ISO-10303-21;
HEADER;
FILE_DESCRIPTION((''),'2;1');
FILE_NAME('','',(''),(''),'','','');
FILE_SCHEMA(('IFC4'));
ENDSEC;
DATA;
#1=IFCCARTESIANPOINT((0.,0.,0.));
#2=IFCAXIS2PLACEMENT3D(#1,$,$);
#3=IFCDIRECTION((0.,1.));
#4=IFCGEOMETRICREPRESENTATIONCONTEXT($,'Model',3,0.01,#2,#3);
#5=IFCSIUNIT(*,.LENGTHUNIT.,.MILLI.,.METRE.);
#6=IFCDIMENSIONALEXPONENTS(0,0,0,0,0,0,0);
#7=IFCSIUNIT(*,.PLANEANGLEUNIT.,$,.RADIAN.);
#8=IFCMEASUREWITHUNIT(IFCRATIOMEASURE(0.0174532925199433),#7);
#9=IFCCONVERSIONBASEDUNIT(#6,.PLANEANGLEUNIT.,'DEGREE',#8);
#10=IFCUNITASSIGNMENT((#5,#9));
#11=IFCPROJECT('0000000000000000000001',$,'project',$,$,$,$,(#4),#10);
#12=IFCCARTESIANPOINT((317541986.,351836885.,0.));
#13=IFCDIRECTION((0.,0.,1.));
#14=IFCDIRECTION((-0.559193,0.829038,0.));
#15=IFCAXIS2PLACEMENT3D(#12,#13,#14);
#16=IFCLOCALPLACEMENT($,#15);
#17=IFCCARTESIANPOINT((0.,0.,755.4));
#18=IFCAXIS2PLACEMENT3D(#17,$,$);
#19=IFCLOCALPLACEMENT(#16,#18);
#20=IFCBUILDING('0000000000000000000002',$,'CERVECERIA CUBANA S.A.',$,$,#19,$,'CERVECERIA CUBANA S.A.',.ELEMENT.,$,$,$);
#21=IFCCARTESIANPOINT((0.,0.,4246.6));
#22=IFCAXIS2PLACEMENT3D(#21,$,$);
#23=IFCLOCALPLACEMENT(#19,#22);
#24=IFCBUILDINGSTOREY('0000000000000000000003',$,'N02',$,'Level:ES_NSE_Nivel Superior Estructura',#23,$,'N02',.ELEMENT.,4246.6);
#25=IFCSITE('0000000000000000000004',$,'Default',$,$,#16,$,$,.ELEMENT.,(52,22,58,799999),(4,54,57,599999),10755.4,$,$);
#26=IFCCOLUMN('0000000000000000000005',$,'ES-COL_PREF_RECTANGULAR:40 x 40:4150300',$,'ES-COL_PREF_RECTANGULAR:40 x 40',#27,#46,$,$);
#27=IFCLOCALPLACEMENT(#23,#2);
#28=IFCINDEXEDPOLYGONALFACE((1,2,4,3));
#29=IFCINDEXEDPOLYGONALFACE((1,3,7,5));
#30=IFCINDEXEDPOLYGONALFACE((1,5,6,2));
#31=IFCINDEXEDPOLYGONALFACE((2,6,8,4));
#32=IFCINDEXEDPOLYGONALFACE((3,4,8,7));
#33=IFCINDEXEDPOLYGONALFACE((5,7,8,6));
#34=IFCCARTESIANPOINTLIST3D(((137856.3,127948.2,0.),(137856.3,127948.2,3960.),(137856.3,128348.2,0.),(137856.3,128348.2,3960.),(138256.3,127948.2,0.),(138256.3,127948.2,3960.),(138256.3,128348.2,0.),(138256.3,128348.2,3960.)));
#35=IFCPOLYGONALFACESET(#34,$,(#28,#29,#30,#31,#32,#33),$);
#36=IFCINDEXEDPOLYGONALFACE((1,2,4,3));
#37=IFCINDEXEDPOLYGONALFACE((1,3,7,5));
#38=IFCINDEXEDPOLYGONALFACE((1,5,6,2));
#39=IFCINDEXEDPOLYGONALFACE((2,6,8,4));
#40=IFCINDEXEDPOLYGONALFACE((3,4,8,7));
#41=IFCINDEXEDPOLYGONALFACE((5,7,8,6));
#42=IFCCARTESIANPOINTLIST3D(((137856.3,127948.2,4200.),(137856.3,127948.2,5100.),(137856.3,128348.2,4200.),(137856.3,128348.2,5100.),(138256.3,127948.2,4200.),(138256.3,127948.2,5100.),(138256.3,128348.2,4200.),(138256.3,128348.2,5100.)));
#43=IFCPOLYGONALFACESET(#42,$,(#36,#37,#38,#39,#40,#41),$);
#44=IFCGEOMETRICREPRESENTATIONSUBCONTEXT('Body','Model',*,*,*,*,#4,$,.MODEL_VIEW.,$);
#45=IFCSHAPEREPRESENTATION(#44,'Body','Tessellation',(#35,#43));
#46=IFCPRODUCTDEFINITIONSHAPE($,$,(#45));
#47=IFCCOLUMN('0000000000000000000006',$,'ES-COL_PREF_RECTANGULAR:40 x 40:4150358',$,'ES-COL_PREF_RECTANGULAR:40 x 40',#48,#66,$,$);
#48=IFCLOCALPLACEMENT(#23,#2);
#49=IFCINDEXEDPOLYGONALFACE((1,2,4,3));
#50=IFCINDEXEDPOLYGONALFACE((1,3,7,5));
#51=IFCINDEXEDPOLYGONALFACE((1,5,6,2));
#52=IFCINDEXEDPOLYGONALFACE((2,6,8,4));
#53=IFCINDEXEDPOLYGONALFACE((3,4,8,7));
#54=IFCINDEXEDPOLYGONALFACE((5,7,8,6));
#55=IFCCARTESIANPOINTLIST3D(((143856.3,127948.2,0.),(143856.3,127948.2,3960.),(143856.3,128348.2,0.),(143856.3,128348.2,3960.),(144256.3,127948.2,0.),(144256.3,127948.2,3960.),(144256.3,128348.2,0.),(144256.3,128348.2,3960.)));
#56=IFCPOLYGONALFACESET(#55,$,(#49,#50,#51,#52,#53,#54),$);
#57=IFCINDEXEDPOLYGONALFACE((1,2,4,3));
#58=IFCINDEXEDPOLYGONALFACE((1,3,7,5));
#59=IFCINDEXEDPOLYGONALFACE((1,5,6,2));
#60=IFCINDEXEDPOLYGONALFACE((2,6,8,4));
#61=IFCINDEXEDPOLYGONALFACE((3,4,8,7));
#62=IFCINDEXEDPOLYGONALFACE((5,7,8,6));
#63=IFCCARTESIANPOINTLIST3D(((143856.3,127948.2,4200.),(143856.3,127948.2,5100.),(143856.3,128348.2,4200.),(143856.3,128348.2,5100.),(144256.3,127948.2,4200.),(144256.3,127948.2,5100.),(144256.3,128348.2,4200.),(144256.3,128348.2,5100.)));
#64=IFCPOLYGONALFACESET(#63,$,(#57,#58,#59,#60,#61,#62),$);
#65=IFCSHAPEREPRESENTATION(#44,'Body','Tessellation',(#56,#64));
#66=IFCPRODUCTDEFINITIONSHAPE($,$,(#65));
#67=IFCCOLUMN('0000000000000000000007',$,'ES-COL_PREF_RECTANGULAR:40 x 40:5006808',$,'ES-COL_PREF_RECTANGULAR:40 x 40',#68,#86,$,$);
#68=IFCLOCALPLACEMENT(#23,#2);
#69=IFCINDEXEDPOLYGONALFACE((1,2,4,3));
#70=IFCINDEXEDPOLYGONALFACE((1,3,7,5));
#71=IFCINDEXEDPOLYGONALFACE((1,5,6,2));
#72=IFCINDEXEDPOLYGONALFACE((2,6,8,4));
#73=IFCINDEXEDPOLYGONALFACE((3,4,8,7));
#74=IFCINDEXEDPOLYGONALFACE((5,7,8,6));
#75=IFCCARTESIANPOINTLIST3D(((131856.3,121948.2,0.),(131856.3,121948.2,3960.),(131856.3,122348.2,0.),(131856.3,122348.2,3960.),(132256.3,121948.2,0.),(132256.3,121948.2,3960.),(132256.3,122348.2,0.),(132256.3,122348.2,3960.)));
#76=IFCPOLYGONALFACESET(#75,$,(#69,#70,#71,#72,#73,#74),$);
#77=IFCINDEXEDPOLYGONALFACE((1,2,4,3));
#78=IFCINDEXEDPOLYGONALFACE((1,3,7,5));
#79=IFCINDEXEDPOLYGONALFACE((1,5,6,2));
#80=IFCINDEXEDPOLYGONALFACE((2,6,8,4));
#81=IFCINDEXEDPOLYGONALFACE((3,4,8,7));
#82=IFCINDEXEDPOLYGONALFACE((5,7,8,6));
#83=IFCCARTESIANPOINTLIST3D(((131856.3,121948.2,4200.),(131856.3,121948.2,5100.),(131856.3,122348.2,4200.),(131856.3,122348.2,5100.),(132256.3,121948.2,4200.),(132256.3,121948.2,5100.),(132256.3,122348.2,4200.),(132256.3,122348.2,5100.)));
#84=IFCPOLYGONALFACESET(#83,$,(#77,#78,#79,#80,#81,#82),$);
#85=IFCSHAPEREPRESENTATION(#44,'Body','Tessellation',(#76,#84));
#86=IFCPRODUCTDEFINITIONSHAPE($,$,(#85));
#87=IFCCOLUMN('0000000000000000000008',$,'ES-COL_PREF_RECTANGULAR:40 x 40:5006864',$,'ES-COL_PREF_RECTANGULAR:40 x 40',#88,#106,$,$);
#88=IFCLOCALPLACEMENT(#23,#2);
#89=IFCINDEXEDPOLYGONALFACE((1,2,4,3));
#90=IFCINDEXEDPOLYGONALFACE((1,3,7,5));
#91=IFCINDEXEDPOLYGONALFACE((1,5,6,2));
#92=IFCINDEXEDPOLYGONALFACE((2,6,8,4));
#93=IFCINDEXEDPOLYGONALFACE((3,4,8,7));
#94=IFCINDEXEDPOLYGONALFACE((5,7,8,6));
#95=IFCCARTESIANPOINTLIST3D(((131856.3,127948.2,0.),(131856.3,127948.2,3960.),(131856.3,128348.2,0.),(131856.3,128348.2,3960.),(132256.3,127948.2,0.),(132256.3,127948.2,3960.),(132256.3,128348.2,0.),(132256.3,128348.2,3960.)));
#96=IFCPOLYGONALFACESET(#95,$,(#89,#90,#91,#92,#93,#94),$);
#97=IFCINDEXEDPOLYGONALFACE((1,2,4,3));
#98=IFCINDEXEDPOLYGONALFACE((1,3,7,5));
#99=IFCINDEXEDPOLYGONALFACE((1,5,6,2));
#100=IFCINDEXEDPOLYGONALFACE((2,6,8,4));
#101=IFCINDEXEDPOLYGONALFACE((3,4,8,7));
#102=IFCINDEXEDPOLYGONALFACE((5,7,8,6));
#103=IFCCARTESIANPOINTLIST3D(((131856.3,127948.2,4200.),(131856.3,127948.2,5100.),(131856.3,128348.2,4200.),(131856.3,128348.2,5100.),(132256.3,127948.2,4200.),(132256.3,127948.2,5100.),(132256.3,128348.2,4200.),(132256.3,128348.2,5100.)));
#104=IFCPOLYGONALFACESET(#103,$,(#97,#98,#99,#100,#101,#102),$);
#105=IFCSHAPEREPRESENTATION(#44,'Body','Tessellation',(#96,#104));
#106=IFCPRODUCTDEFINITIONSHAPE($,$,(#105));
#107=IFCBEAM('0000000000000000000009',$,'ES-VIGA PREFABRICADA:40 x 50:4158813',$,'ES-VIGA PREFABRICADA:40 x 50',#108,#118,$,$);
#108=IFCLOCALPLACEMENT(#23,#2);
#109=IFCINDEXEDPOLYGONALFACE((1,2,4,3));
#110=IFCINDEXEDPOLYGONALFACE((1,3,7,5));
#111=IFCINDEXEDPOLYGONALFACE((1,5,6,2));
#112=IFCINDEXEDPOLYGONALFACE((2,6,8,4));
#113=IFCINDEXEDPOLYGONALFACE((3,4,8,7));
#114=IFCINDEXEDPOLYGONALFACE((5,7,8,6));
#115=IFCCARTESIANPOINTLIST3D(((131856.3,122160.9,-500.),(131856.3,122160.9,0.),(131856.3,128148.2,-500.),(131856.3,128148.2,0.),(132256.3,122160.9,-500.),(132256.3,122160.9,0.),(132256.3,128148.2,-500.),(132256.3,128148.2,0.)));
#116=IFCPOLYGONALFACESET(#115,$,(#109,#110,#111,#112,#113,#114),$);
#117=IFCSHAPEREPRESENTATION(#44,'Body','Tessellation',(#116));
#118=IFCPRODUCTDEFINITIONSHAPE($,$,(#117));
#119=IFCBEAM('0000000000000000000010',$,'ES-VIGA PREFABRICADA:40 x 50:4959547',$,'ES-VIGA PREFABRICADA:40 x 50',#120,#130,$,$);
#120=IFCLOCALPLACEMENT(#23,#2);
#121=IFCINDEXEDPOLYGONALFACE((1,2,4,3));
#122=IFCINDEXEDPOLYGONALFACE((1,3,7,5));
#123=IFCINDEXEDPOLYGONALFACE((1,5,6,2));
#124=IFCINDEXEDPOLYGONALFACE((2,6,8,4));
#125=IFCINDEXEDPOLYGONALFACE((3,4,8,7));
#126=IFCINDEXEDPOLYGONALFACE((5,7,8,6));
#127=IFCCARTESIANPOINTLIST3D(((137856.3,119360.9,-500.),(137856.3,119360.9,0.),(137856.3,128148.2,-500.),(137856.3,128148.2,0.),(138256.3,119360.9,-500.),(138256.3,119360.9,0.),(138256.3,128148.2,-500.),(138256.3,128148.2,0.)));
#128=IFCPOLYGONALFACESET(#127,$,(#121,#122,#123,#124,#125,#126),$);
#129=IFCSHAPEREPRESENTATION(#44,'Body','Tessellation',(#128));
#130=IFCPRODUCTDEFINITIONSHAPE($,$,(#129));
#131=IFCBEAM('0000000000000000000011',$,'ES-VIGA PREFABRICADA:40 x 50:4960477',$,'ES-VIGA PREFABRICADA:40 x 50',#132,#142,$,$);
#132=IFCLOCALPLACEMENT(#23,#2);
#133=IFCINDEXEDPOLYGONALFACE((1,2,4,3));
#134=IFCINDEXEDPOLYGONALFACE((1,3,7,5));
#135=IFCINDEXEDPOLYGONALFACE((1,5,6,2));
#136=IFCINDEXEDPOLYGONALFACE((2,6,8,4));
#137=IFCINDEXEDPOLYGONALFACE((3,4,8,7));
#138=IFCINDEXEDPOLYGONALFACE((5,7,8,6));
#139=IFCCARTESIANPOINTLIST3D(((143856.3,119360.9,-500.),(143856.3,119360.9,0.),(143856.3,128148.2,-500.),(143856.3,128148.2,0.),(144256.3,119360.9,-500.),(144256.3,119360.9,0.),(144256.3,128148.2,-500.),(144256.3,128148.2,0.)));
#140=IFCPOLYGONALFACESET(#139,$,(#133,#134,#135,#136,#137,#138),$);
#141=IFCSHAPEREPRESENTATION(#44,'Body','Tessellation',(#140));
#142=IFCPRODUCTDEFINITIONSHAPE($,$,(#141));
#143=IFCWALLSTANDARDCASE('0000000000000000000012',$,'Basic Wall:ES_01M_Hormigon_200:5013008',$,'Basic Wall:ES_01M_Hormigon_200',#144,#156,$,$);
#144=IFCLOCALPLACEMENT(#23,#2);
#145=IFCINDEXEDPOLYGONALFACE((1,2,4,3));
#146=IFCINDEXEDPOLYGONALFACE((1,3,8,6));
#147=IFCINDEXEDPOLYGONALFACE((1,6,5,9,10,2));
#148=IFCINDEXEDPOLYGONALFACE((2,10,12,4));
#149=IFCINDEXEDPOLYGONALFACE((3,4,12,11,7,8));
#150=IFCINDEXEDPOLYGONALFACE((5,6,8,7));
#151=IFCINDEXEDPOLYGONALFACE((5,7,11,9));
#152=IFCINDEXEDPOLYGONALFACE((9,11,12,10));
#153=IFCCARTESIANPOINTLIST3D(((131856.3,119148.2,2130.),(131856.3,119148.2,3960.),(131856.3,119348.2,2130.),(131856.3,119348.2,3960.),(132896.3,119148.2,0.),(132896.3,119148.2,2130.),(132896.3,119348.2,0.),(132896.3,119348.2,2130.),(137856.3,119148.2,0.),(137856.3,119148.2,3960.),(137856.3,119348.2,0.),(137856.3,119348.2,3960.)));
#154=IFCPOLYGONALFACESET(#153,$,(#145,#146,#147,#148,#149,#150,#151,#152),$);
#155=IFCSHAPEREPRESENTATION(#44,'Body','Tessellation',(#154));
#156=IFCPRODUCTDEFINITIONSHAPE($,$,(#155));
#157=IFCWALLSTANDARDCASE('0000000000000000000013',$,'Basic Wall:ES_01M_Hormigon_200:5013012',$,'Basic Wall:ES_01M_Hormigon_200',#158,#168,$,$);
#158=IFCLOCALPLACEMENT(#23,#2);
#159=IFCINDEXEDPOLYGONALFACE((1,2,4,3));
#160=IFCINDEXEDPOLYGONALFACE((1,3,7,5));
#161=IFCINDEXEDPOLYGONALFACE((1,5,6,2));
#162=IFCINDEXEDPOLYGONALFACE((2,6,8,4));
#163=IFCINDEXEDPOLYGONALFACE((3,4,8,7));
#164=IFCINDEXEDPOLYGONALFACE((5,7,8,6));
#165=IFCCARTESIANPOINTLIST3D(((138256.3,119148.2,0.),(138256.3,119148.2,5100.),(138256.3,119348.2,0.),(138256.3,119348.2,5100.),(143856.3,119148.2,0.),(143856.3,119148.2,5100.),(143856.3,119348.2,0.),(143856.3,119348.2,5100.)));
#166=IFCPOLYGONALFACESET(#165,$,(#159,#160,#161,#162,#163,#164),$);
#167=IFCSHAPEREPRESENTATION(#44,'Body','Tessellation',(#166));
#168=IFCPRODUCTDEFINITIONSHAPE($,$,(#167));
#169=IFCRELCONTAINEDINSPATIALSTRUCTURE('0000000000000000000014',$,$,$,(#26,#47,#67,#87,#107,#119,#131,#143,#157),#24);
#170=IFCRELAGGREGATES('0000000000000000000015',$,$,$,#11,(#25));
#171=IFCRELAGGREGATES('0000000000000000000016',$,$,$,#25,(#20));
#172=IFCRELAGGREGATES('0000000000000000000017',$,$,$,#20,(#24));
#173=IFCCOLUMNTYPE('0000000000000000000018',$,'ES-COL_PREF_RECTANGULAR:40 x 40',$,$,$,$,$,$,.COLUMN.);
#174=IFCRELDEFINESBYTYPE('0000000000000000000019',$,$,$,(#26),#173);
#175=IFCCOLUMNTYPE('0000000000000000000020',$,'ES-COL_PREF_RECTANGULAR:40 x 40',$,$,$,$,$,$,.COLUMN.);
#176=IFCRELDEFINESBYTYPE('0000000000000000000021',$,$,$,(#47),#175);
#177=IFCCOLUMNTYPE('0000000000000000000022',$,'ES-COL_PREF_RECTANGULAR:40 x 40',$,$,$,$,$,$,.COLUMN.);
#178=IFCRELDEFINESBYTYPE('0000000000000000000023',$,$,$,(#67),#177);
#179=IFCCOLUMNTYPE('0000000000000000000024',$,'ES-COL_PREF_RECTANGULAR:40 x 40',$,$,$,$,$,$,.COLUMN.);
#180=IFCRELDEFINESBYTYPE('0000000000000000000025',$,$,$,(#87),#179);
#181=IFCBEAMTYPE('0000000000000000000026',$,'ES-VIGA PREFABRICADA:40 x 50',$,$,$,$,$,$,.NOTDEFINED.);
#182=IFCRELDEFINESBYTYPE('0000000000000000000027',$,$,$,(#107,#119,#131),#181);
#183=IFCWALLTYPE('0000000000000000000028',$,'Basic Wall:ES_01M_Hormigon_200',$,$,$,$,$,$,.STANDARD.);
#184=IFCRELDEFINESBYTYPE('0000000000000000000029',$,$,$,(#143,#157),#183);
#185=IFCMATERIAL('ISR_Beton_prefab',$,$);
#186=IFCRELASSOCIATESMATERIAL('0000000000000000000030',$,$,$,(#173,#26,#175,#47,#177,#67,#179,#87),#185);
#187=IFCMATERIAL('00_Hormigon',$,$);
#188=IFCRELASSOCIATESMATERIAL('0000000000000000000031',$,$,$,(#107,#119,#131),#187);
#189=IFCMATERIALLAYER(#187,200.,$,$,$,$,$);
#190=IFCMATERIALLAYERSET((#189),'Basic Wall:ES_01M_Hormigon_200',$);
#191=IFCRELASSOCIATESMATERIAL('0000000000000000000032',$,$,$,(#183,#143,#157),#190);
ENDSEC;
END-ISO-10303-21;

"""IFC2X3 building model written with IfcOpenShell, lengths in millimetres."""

from ifc_helpers import new_model, entity, si_unit, converted_unit, direction, frame, frame_2d, origin, origin_2d_with_axis, place, context, subcontext, project, spatial, rectangle, extrude, source, transform, mapped, material, layer, layer_set, layer_usage, type_object, type_shapes, element, save


model = new_model("IFC2X3")

# Units and contexts
model_context = context("Model", 3, precision=0.01, world=origin(), true_north=direction((0.0, 1.0)))
body_context = subcontext(model_context, "Body", "Model", "MODEL_VIEW")
ifc_project = project(units=[si_unit("LENGTHUNIT", "METRE", prefix="MILLI"), converted_unit("PLANEANGLEUNIT", "DEGREE", entity("IfcRatioMeasure", 0.0174532925199433), si_unit("PLANEANGLEUNIT", "RADIAN"), dimensions=[0, 0, 0, 0, 0, 0, 0])], contexts=[model_context])

# Site, building, storey
site_placement = place(None, frame((317541986.0, 351836885.0, 0.0), z_axis=(0.0, 0.0, 1.0), x_axis=(-0.559193, 0.829038, 0.0)))
site = spatial("IfcSite", under=ifc_project, at=site_placement, Name="Default", CompositionType="ELEMENT", RefLatitude=(52, 22, 58, 799999), RefLongitude=(4, 54, 57, 599999), RefElevation=10755.4)
building_placement = place(site_placement, frame((0.0, 0.0, 755.4)))
building = spatial("IfcBuilding", under=site, at=building_placement, Name="CERVECERIA CUBANA S.A.", LongName="CERVECERIA CUBANA S.A.", CompositionType="ELEMENT")
storey_placement = place(building_placement, frame((0.0, 0.0, 4246.6)))
storey = spatial("IfcBuildingStorey", under=building, at=storey_placement, Name="N02", ObjectType="Level:ES_NSE_Nivel Superior Estructura", LongName="N02", CompositionType="ELEMENT", Elevation=4246.6)

# Columns
ifc_material_1 = material(Name="ISR_Beton_prefab")
column_type_1 = type_object("IfcColumnType", Name="ES-COL_PREF_RECTANGULAR:40 x 40", PredefinedType="COLUMN", material=ifc_material_1)
shared_shape_1 = source(origin(), body_context, "Body", "SweptSolid", [
    extrude(rectangle(XDim=400.0, YDim=400.0, at=origin_2d_with_axis()), frame((138056.3, 128148.2, 4246.6), z_axis=(0.0, 0.0, 1.0), x_axis=(0.0, -1.0, 0.0)), (0.0, 0.0, 1.0), 3960.0),
    extrude(rectangle(XDim=400.0, YDim=400.0, at=origin_2d_with_axis()), frame((138056.3, 128148.2, 8446.6), z_axis=(0.0, 0.0, 1.0), x_axis=(0.0, -1.0, 0.0)), (0.0, 0.0, 1.0), 900.0),
])
type_shapes(column_type_1, [shared_shape_1])
column_1_placement = place(storey_placement, frame((0.0, 0.0, -4246.6)))
element("IfcColumn", 1, at=column_1_placement, inside=storey, type_object=column_type_1, material=ifc_material_1, Name="ES-COL_PREF_RECTANGULAR:40 x 40:4150300", ObjectType="ES-COL_PREF_RECTANGULAR:40 x 40", context=body_context, shape_type="MappedRepresentation", body=[
    mapped(shared_shape_1, transform((0.0, 0.0, 0.0), scale=1.0)),
])
column_type_2 = type_object("IfcColumnType", Name="ES-COL_PREF_RECTANGULAR:40 x 40", PredefinedType="COLUMN", material=ifc_material_1)
shared_shape_2 = source(origin(), body_context, "Body", "SweptSolid", [
    extrude(rectangle(XDim=400.0, YDim=400.0, at=origin_2d_with_axis()), frame((144056.3, 128148.2, 4246.6), z_axis=(0.0, 0.0, 1.0), x_axis=(0.0, -1.0, 0.0)), (0.0, 0.0, 1.0), 3960.0),
    extrude(rectangle(XDim=400.0, YDim=400.0, at=origin_2d_with_axis()), frame((144056.3, 128148.2, 8446.6), z_axis=(0.0, 0.0, 1.0), x_axis=(0.0, -1.0, 0.0)), (0.0, 0.0, 1.0), 900.0),
])
type_shapes(column_type_2, [shared_shape_2])
column_2_placement = place(storey_placement, frame((0.0, 0.0, -4246.6)))
element("IfcColumn", 2, at=column_2_placement, inside=storey, type_object=column_type_2, material=ifc_material_1, Name="ES-COL_PREF_RECTANGULAR:40 x 40:4150358", ObjectType="ES-COL_PREF_RECTANGULAR:40 x 40", context=body_context, shape_type="MappedRepresentation", body=[
    mapped(shared_shape_2, transform((0.0, 0.0, 0.0), scale=1.0)),
])
column_type_3 = type_object("IfcColumnType", Name="ES-COL_PREF_RECTANGULAR:40 x 40", PredefinedType="COLUMN", material=ifc_material_1)
shared_shape_3 = source(origin(), body_context, "Body", "SweptSolid", [
    extrude(rectangle(XDim=400.0, YDim=400.0, at=origin_2d_with_axis()), frame((132056.3, 122148.2, 4246.6), z_axis=(0.0, 0.0, 1.0), x_axis=(0.0, -1.0, 0.0)), (0.0, 0.0, 1.0), 3960.0),
    extrude(rectangle(XDim=400.0, YDim=400.0, at=origin_2d_with_axis()), frame((132056.3, 122148.2, 8446.6), z_axis=(0.0, 0.0, 1.0), x_axis=(0.0, -1.0, 0.0)), (0.0, 0.0, 1.0), 900.0),
])
type_shapes(column_type_3, [shared_shape_3])
column_3_placement = place(storey_placement, frame((0.0, 0.0, -4246.6)))
element("IfcColumn", 3, at=column_3_placement, inside=storey, type_object=column_type_3, material=ifc_material_1, Name="ES-COL_PREF_RECTANGULAR:40 x 40:5006808", ObjectType="ES-COL_PREF_RECTANGULAR:40 x 40", context=body_context, shape_type="MappedRepresentation", body=[
    mapped(shared_shape_3, transform((0.0, 0.0, 0.0), scale=1.0)),
])
column_type_4 = type_object("IfcColumnType", Name="ES-COL_PREF_RECTANGULAR:40 x 40", PredefinedType="COLUMN", material=ifc_material_1)
shared_shape_4 = source(origin(), body_context, "Body", "SweptSolid", [
    extrude(rectangle(XDim=400.0, YDim=400.0, at=origin_2d_with_axis()), frame((132056.3, 128148.2, 4246.6), z_axis=(0.0, 0.0, 1.0), x_axis=(0.0, -1.0, 0.0)), (0.0, 0.0, 1.0), 3960.0),
    extrude(rectangle(XDim=400.0, YDim=400.0, at=origin_2d_with_axis()), frame((132056.3, 128148.2, 8446.6), z_axis=(0.0, 0.0, 1.0), x_axis=(0.0, -1.0, 0.0)), (0.0, 0.0, 1.0), 900.0),
])
type_shapes(column_type_4, [shared_shape_4])
column_4_placement = place(storey_placement, frame((0.0, 0.0, -4246.6)))
element("IfcColumn", 4, at=column_4_placement, inside=storey, type_object=column_type_4, material=ifc_material_1, Name="ES-COL_PREF_RECTANGULAR:40 x 40:5006864", ObjectType="ES-COL_PREF_RECTANGULAR:40 x 40", context=body_context, shape_type="MappedRepresentation", body=[
    mapped(shared_shape_4, transform((0.0, 0.0, 0.0), scale=1.0)),
])

# Beams
ifc_material_2 = material(Name="00_Hormigon")
beam_type = type_object("IfcBeamType", Name="ES-VIGA PREFABRICADA:40 x 50", PredefinedType="NOTDEFINED")
beam_1_placement = place(storey_placement, frame((132056.3, 128148.2, 0.0), z_axis=(0.0, 0.0, 1.0), x_axis=(0.0, -1.0, 0.0)))
element("IfcBeam", 5, at=beam_1_placement, inside=storey, type_object=beam_type, material=ifc_material_2, Name="ES-VIGA PREFABRICADA:40 x 50:4158813", ObjectType="ES-VIGA PREFABRICADA:40 x 50", context=body_context, shape_type="SweptSolid", body=[
    extrude(rectangle(XDim=500.0, YDim=400.0, at=origin_2d_with_axis()), frame((0.0, 0.0, -250.0), z_axis=(1.0, 0.0, 0.0), x_axis=(0.0, 0.0, -1.0)), (0.0, 0.0, 1.0), 5987.3),
])
for number, where, z_axis, x_axis, name in (
    (6, (138056.3, 128148.2, 0.0), (0.0, 0.0, 1.0), (0.0, -1.0, 0.0), "ES-VIGA PREFABRICADA:40 x 50:4959547"),
    (7, (144056.3, 128148.2, 0.0), (0.0, 0.0, 1.0), (0.0, -1.0, 0.0), "ES-VIGA PREFABRICADA:40 x 50:4960477"),
):
    element("IfcBeam", number, at=place(storey_placement, frame(where, z_axis=z_axis, x_axis=x_axis)), inside=storey, type_object=beam_type, material=ifc_material_2, Name=name, ObjectType="ES-VIGA PREFABRICADA:40 x 50", context=body_context, shape_type="SweptSolid", body=[
        extrude(rectangle(XDim=500.0, YDim=400.0, at=origin_2d_with_axis()), frame((0.0, 0.0, -250.0), z_axis=(1.0, 0.0, 0.0), x_axis=(0.0, 0.0, -1.0)), (0.0, 0.0, 1.0), 8787.3),
    ])

# Wall, opening
ifc_layer_1 = layer(ifc_material_2, 200.0)
ifc_layer_set_1 = layer_set([ifc_layer_1], Name="Basic Wall:ES_01M_Hormigon_200")
ifc_layer_usage_1 = layer_usage(ifc_layer_set_1, "AXIS2", "NEGATIVE", 100.0)
wall_type_1 = type_object("IfcWallType", Name="Basic Wall:ES_01M_Hormigon_200", PredefinedType="STANDARD", material=ifc_layer_set_1)
wall_1_placement = place(storey_placement, frame((131856.3, 119248.2, 0.0)))
wall_1 = element("IfcWallStandardCase", 8, at=wall_1_placement, inside=storey, type_object=wall_type_1, material=ifc_layer_usage_1, Name="Basic Wall:ES_01M_Hormigon_200:5013008", ObjectType="Basic Wall:ES_01M_Hormigon_200", context=body_context, shape_type="SweptSolid", body=[
    extrude(rectangle(XDim=6000.0, YDim=200.0, at=frame_2d((3000.0, 0.0), x_axis=(-1.0, 0.0))), origin(), (0.0, 0.0, 1.0), 3960.0),
])
opening_1_placement = place(wall_1_placement, frame((-131856.3, -119248.2, 0.0)))
element("IfcOpeningElement", 9, at=opening_1_placement, cuts=wall_1, ObjectType="Opening", context=body_context, shape_type="SweptSolid", body=[
    extrude(rectangle(XDim=2130.0, YDim=1040.0, at=frame_2d((0.0, 0.0), x_axis=(1.0, 0.0))), frame((132376.3, 117824.2, 1065.0), z_axis=(0.0, 1.0, 0.0), x_axis=(0.0, 0.0, -1.0)), (0.0, 0.0, 1.0), 3048.0),
])

# Wall
ifc_layer_usage_2 = layer_usage(ifc_layer_set_1, "AXIS2", "NEGATIVE", 100.0)
wall_2_placement = place(storey_placement, frame((138256.3, 119248.2, 0.0)))
element("IfcWallStandardCase", 10, at=wall_2_placement, inside=storey, type_object=wall_type_1, material=ifc_layer_usage_2, Name="Basic Wall:ES_01M_Hormigon_200:5013012", ObjectType="Basic Wall:ES_01M_Hormigon_200", context=body_context, shape_type="SweptSolid", body=[
    extrude(rectangle(XDim=5600.0, YDim=200.0, at=frame_2d((2800.0, 0.0), x_axis=(-1.0, 0.0))), origin(), (0.0, 0.0, 1.0), 5100.0),
])

save(model, "model.ifc")
